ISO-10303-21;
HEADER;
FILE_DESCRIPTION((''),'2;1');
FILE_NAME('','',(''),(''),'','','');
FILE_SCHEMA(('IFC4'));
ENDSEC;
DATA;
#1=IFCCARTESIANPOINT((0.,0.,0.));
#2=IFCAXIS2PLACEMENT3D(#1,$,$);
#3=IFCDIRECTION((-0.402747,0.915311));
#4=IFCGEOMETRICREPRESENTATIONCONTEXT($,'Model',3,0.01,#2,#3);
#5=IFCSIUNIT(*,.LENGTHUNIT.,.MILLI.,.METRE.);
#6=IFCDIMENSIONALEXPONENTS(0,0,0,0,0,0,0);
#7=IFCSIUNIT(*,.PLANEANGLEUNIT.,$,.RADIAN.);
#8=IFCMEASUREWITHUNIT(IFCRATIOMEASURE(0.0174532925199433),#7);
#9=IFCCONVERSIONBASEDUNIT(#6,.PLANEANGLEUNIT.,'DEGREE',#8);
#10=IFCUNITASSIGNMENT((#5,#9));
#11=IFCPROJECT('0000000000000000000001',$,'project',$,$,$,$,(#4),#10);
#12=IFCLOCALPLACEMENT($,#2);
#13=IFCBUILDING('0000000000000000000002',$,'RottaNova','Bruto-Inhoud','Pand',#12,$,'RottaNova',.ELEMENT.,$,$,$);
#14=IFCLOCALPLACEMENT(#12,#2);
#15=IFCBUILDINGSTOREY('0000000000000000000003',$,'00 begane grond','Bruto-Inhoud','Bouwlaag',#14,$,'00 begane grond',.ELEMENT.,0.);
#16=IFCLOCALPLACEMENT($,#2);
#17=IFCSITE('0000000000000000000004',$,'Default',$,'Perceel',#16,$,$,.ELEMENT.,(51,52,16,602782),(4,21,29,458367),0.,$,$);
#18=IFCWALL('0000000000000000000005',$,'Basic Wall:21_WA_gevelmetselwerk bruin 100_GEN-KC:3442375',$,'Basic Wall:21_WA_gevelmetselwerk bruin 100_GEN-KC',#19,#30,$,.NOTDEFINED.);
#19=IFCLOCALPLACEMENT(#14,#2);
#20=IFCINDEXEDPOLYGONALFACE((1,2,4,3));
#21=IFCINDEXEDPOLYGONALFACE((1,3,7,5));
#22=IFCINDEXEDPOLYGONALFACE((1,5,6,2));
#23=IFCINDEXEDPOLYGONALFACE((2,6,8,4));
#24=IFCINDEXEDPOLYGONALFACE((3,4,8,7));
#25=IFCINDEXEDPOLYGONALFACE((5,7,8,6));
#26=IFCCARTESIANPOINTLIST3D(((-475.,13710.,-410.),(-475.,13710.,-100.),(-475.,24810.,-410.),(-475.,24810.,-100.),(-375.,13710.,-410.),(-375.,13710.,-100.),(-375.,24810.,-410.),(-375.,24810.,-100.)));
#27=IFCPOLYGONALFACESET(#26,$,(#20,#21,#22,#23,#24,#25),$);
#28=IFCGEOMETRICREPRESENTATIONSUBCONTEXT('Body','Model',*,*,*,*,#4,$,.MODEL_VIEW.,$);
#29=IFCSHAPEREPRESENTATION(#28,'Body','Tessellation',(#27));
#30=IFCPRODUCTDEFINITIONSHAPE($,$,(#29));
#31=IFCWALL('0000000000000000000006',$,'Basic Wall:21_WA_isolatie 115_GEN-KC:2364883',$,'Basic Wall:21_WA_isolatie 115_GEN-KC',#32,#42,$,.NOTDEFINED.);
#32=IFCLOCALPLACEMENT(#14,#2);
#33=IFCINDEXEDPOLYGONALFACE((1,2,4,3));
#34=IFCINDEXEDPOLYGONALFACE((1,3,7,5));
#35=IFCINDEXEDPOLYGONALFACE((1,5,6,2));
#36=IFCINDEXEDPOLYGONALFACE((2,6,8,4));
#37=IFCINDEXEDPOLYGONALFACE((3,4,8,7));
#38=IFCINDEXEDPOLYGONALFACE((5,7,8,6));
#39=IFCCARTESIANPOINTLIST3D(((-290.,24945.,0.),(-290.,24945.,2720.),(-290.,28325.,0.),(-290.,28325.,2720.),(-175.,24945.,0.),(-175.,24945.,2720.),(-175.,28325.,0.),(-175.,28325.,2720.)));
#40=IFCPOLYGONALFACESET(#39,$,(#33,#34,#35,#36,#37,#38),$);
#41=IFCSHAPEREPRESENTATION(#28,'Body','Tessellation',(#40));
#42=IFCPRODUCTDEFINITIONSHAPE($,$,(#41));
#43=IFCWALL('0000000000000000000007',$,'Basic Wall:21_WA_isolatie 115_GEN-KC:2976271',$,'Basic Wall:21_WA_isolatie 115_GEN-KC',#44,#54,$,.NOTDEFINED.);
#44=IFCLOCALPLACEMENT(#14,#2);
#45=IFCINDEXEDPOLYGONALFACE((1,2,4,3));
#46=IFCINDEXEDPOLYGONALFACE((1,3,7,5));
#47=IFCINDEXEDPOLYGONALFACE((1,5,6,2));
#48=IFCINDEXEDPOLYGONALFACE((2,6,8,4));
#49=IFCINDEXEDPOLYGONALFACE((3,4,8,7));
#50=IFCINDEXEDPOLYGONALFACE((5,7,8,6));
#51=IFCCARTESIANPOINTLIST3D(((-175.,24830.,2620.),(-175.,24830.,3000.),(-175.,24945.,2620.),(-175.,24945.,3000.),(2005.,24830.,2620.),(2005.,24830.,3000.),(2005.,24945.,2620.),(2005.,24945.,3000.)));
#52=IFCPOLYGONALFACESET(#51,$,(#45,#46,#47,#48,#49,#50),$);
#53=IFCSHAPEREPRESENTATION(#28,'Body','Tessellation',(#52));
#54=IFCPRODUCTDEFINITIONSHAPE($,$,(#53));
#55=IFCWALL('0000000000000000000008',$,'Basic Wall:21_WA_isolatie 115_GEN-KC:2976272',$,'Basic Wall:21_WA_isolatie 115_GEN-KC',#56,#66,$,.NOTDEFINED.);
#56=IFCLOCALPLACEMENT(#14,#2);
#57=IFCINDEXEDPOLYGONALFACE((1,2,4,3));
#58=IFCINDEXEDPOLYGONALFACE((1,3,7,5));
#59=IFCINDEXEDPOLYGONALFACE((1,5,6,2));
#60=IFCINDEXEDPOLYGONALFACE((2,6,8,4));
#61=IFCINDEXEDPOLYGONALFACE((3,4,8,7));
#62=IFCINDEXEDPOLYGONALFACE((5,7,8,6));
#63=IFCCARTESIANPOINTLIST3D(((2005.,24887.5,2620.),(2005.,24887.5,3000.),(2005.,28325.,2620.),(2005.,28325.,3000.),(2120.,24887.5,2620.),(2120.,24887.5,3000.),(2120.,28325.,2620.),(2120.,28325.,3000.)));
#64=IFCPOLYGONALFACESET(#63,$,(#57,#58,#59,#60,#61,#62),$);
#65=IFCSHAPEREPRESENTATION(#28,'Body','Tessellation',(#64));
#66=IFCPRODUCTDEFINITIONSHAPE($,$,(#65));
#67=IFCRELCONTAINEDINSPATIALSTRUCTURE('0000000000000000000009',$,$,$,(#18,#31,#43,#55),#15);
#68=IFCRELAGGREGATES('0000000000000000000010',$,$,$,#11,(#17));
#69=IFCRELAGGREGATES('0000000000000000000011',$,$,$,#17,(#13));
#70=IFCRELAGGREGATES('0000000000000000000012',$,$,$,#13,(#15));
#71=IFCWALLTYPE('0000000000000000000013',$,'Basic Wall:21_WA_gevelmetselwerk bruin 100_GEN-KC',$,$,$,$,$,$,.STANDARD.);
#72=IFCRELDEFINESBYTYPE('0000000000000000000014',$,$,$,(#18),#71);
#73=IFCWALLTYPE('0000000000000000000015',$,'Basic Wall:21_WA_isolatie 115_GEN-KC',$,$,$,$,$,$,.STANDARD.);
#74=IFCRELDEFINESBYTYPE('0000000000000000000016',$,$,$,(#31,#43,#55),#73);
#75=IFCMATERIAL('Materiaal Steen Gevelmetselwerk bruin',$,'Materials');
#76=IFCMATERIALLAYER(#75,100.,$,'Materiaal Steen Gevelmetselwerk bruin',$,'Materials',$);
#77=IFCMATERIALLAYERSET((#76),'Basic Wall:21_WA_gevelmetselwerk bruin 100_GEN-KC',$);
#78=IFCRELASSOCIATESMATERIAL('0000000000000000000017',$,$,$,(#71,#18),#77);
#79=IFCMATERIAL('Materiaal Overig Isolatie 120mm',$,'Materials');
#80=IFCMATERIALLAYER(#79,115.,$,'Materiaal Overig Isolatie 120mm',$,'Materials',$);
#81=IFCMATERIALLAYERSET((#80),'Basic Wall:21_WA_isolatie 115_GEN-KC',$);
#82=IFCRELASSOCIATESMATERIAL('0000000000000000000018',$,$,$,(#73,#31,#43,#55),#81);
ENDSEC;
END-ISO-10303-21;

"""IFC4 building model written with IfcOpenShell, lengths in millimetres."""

from ifc_helpers import new_model, entity, si_unit, converted_unit, direction, frame, frame_2d, origin, place, context, subcontext, project, spatial, rectangle, extrude, material, layer, layer_set, type_object, element, save


model = new_model("IFC4")

# Units and contexts
model_context = context("Model", 3, precision=0.01, world=origin(), true_north=direction((-0.402747, 0.915311)))
body_context = subcontext(model_context, "Body", "Model", "MODEL_VIEW")
ifc_project = project(units=[si_unit("LENGTHUNIT", "METRE", prefix="MILLI"), converted_unit("PLANEANGLEUNIT", "DEGREE", entity("IfcRatioMeasure", 0.0174532925199433), si_unit("PLANEANGLEUNIT", "RADIAN"), dimensions=[0, 0, 0, 0, 0, 0, 0])], contexts=[model_context])

# Site, building, storey
site_placement = place(None, origin())
site = spatial("IfcSite", under=ifc_project, at=site_placement, Name="Default", ObjectType="Perceel", CompositionType="ELEMENT", RefLatitude=(51, 52, 16, 602782), RefLongitude=(4, 21, 29, 458367), RefElevation=0.0)
building_placement = place(None, origin())
building = spatial("IfcBuilding", under=site, at=building_placement, Name="RottaNova", Description="Bruto-Inhoud", ObjectType="Pand", LongName="RottaNova", CompositionType="ELEMENT")
storey_placement = place(building_placement, origin())
storey = spatial("IfcBuildingStorey", under=building, at=storey_placement, Name="00 begane grond", Description="Bruto-Inhoud", ObjectType="Bouwlaag", LongName="00 begane grond", CompositionType="ELEMENT", Elevation=0.0)

# Walls
ifc_material_1 = material(Name="Materiaal Steen Gevelmetselwerk bruin", Category="Materials")
ifc_layer_1 = layer(ifc_material_1, 100.0, Name="Materiaal Steen Gevelmetselwerk bruin", Category="Materials")
ifc_layer_set_1 = layer_set([ifc_layer_1], Name="Basic Wall:21_WA_gevelmetselwerk bruin 100_GEN-KC")
wall_type_1 = type_object("IfcWallType", Name="Basic Wall:21_WA_gevelmetselwerk bruin 100_GEN-KC", PredefinedType="STANDARD", material=ifc_layer_set_1)
wall_1_placement = place(storey_placement, frame((-425.0, 13710.0, -410.0), z_axis=(0.0, 0.0, 1.0), x_axis=(0.0, 1.0, 0.0)))
element("IfcWall", 1, at=wall_1_placement, inside=storey, type_object=wall_type_1, material=ifc_layer_set_1, Name="Basic Wall:21_WA_gevelmetselwerk bruin 100_GEN-KC:3442375", ObjectType="Basic Wall:21_WA_gevelmetselwerk bruin 100_GEN-KC", PredefinedType="NOTDEFINED", context=body_context, shape_type="SweptSolid", body=[
    extrude(rectangle(XDim=11100.0, YDim=100.0, at=frame_2d((5550.0, 0.0), x_axis=(-1.0, 0.0))), origin(), (0.0, 0.0, 1.0), 310.0),
])
ifc_material_2 = material(Name="Materiaal Overig Isolatie 120mm", Category="Materials")
ifc_layer_2 = layer(ifc_material_2, 115.0, Name="Materiaal Overig Isolatie 120mm", Category="Materials")
ifc_layer_set_2 = layer_set([ifc_layer_2], Name="Basic Wall:21_WA_isolatie 115_GEN-KC")
wall_type_2 = type_object("IfcWallType", Name="Basic Wall:21_WA_isolatie 115_GEN-KC", PredefinedType="STANDARD", material=ifc_layer_set_2)
wall_2_placement = place(storey_placement, frame((-232.5, 24945.0, 0.0), z_axis=(0.0, 0.0, 1.0), x_axis=(0.0, 1.0, 0.0)))
element("IfcWall", 2, at=wall_2_placement, inside=storey, type_object=wall_type_2, material=ifc_layer_set_2, Name="Basic Wall:21_WA_isolatie 115_GEN-KC:2364883", ObjectType="Basic Wall:21_WA_isolatie 115_GEN-KC", PredefinedType="NOTDEFINED", context=body_context, shape_type="SweptSolid", body=[
    extrude(rectangle(XDim=3380.0, YDim=115.0, at=frame_2d((1690.0, 0.0), x_axis=(-1.0, 0.0))), origin(), (0.0, 0.0, 1.0), 2720.0),
])
wall_3_placement = place(storey_placement, frame((-175.0, 24887.5, 2620.0)))
element("IfcWall", 3, at=wall_3_placement, inside=storey, type_object=wall_type_2, material=ifc_layer_set_2, Name="Basic Wall:21_WA_isolatie 115_GEN-KC:2976271", ObjectType="Basic Wall:21_WA_isolatie 115_GEN-KC", PredefinedType="NOTDEFINED", context=body_context, shape_type="SweptSolid", body=[
    extrude(rectangle(XDim=2180.0, YDim=115.0, at=frame_2d((1090.0, 0.0), x_axis=(-1.0, 0.0))), origin(), (0.0, 0.0, 1.0), 380.0),
])
wall_4_placement = place(storey_placement, frame((2062.5, 24887.5, 2620.0), z_axis=(0.0, 0.0, 1.0), x_axis=(0.0, 1.0, 0.0)))
element("IfcWall", 4, at=wall_4_placement, inside=storey, type_object=wall_type_2, material=ifc_layer_set_2, Name="Basic Wall:21_WA_isolatie 115_GEN-KC:2976272", ObjectType="Basic Wall:21_WA_isolatie 115_GEN-KC", PredefinedType="NOTDEFINED", context=body_context, shape_type="SweptSolid", body=[
    extrude(rectangle(XDim=3437.5, YDim=115.0, at=frame_2d((1718.7, 0.0), x_axis=(-1.0, 0.0))), origin(), (0.0, 0.0, 1.0), 380.0),
])

save(model, "model.ifc")
